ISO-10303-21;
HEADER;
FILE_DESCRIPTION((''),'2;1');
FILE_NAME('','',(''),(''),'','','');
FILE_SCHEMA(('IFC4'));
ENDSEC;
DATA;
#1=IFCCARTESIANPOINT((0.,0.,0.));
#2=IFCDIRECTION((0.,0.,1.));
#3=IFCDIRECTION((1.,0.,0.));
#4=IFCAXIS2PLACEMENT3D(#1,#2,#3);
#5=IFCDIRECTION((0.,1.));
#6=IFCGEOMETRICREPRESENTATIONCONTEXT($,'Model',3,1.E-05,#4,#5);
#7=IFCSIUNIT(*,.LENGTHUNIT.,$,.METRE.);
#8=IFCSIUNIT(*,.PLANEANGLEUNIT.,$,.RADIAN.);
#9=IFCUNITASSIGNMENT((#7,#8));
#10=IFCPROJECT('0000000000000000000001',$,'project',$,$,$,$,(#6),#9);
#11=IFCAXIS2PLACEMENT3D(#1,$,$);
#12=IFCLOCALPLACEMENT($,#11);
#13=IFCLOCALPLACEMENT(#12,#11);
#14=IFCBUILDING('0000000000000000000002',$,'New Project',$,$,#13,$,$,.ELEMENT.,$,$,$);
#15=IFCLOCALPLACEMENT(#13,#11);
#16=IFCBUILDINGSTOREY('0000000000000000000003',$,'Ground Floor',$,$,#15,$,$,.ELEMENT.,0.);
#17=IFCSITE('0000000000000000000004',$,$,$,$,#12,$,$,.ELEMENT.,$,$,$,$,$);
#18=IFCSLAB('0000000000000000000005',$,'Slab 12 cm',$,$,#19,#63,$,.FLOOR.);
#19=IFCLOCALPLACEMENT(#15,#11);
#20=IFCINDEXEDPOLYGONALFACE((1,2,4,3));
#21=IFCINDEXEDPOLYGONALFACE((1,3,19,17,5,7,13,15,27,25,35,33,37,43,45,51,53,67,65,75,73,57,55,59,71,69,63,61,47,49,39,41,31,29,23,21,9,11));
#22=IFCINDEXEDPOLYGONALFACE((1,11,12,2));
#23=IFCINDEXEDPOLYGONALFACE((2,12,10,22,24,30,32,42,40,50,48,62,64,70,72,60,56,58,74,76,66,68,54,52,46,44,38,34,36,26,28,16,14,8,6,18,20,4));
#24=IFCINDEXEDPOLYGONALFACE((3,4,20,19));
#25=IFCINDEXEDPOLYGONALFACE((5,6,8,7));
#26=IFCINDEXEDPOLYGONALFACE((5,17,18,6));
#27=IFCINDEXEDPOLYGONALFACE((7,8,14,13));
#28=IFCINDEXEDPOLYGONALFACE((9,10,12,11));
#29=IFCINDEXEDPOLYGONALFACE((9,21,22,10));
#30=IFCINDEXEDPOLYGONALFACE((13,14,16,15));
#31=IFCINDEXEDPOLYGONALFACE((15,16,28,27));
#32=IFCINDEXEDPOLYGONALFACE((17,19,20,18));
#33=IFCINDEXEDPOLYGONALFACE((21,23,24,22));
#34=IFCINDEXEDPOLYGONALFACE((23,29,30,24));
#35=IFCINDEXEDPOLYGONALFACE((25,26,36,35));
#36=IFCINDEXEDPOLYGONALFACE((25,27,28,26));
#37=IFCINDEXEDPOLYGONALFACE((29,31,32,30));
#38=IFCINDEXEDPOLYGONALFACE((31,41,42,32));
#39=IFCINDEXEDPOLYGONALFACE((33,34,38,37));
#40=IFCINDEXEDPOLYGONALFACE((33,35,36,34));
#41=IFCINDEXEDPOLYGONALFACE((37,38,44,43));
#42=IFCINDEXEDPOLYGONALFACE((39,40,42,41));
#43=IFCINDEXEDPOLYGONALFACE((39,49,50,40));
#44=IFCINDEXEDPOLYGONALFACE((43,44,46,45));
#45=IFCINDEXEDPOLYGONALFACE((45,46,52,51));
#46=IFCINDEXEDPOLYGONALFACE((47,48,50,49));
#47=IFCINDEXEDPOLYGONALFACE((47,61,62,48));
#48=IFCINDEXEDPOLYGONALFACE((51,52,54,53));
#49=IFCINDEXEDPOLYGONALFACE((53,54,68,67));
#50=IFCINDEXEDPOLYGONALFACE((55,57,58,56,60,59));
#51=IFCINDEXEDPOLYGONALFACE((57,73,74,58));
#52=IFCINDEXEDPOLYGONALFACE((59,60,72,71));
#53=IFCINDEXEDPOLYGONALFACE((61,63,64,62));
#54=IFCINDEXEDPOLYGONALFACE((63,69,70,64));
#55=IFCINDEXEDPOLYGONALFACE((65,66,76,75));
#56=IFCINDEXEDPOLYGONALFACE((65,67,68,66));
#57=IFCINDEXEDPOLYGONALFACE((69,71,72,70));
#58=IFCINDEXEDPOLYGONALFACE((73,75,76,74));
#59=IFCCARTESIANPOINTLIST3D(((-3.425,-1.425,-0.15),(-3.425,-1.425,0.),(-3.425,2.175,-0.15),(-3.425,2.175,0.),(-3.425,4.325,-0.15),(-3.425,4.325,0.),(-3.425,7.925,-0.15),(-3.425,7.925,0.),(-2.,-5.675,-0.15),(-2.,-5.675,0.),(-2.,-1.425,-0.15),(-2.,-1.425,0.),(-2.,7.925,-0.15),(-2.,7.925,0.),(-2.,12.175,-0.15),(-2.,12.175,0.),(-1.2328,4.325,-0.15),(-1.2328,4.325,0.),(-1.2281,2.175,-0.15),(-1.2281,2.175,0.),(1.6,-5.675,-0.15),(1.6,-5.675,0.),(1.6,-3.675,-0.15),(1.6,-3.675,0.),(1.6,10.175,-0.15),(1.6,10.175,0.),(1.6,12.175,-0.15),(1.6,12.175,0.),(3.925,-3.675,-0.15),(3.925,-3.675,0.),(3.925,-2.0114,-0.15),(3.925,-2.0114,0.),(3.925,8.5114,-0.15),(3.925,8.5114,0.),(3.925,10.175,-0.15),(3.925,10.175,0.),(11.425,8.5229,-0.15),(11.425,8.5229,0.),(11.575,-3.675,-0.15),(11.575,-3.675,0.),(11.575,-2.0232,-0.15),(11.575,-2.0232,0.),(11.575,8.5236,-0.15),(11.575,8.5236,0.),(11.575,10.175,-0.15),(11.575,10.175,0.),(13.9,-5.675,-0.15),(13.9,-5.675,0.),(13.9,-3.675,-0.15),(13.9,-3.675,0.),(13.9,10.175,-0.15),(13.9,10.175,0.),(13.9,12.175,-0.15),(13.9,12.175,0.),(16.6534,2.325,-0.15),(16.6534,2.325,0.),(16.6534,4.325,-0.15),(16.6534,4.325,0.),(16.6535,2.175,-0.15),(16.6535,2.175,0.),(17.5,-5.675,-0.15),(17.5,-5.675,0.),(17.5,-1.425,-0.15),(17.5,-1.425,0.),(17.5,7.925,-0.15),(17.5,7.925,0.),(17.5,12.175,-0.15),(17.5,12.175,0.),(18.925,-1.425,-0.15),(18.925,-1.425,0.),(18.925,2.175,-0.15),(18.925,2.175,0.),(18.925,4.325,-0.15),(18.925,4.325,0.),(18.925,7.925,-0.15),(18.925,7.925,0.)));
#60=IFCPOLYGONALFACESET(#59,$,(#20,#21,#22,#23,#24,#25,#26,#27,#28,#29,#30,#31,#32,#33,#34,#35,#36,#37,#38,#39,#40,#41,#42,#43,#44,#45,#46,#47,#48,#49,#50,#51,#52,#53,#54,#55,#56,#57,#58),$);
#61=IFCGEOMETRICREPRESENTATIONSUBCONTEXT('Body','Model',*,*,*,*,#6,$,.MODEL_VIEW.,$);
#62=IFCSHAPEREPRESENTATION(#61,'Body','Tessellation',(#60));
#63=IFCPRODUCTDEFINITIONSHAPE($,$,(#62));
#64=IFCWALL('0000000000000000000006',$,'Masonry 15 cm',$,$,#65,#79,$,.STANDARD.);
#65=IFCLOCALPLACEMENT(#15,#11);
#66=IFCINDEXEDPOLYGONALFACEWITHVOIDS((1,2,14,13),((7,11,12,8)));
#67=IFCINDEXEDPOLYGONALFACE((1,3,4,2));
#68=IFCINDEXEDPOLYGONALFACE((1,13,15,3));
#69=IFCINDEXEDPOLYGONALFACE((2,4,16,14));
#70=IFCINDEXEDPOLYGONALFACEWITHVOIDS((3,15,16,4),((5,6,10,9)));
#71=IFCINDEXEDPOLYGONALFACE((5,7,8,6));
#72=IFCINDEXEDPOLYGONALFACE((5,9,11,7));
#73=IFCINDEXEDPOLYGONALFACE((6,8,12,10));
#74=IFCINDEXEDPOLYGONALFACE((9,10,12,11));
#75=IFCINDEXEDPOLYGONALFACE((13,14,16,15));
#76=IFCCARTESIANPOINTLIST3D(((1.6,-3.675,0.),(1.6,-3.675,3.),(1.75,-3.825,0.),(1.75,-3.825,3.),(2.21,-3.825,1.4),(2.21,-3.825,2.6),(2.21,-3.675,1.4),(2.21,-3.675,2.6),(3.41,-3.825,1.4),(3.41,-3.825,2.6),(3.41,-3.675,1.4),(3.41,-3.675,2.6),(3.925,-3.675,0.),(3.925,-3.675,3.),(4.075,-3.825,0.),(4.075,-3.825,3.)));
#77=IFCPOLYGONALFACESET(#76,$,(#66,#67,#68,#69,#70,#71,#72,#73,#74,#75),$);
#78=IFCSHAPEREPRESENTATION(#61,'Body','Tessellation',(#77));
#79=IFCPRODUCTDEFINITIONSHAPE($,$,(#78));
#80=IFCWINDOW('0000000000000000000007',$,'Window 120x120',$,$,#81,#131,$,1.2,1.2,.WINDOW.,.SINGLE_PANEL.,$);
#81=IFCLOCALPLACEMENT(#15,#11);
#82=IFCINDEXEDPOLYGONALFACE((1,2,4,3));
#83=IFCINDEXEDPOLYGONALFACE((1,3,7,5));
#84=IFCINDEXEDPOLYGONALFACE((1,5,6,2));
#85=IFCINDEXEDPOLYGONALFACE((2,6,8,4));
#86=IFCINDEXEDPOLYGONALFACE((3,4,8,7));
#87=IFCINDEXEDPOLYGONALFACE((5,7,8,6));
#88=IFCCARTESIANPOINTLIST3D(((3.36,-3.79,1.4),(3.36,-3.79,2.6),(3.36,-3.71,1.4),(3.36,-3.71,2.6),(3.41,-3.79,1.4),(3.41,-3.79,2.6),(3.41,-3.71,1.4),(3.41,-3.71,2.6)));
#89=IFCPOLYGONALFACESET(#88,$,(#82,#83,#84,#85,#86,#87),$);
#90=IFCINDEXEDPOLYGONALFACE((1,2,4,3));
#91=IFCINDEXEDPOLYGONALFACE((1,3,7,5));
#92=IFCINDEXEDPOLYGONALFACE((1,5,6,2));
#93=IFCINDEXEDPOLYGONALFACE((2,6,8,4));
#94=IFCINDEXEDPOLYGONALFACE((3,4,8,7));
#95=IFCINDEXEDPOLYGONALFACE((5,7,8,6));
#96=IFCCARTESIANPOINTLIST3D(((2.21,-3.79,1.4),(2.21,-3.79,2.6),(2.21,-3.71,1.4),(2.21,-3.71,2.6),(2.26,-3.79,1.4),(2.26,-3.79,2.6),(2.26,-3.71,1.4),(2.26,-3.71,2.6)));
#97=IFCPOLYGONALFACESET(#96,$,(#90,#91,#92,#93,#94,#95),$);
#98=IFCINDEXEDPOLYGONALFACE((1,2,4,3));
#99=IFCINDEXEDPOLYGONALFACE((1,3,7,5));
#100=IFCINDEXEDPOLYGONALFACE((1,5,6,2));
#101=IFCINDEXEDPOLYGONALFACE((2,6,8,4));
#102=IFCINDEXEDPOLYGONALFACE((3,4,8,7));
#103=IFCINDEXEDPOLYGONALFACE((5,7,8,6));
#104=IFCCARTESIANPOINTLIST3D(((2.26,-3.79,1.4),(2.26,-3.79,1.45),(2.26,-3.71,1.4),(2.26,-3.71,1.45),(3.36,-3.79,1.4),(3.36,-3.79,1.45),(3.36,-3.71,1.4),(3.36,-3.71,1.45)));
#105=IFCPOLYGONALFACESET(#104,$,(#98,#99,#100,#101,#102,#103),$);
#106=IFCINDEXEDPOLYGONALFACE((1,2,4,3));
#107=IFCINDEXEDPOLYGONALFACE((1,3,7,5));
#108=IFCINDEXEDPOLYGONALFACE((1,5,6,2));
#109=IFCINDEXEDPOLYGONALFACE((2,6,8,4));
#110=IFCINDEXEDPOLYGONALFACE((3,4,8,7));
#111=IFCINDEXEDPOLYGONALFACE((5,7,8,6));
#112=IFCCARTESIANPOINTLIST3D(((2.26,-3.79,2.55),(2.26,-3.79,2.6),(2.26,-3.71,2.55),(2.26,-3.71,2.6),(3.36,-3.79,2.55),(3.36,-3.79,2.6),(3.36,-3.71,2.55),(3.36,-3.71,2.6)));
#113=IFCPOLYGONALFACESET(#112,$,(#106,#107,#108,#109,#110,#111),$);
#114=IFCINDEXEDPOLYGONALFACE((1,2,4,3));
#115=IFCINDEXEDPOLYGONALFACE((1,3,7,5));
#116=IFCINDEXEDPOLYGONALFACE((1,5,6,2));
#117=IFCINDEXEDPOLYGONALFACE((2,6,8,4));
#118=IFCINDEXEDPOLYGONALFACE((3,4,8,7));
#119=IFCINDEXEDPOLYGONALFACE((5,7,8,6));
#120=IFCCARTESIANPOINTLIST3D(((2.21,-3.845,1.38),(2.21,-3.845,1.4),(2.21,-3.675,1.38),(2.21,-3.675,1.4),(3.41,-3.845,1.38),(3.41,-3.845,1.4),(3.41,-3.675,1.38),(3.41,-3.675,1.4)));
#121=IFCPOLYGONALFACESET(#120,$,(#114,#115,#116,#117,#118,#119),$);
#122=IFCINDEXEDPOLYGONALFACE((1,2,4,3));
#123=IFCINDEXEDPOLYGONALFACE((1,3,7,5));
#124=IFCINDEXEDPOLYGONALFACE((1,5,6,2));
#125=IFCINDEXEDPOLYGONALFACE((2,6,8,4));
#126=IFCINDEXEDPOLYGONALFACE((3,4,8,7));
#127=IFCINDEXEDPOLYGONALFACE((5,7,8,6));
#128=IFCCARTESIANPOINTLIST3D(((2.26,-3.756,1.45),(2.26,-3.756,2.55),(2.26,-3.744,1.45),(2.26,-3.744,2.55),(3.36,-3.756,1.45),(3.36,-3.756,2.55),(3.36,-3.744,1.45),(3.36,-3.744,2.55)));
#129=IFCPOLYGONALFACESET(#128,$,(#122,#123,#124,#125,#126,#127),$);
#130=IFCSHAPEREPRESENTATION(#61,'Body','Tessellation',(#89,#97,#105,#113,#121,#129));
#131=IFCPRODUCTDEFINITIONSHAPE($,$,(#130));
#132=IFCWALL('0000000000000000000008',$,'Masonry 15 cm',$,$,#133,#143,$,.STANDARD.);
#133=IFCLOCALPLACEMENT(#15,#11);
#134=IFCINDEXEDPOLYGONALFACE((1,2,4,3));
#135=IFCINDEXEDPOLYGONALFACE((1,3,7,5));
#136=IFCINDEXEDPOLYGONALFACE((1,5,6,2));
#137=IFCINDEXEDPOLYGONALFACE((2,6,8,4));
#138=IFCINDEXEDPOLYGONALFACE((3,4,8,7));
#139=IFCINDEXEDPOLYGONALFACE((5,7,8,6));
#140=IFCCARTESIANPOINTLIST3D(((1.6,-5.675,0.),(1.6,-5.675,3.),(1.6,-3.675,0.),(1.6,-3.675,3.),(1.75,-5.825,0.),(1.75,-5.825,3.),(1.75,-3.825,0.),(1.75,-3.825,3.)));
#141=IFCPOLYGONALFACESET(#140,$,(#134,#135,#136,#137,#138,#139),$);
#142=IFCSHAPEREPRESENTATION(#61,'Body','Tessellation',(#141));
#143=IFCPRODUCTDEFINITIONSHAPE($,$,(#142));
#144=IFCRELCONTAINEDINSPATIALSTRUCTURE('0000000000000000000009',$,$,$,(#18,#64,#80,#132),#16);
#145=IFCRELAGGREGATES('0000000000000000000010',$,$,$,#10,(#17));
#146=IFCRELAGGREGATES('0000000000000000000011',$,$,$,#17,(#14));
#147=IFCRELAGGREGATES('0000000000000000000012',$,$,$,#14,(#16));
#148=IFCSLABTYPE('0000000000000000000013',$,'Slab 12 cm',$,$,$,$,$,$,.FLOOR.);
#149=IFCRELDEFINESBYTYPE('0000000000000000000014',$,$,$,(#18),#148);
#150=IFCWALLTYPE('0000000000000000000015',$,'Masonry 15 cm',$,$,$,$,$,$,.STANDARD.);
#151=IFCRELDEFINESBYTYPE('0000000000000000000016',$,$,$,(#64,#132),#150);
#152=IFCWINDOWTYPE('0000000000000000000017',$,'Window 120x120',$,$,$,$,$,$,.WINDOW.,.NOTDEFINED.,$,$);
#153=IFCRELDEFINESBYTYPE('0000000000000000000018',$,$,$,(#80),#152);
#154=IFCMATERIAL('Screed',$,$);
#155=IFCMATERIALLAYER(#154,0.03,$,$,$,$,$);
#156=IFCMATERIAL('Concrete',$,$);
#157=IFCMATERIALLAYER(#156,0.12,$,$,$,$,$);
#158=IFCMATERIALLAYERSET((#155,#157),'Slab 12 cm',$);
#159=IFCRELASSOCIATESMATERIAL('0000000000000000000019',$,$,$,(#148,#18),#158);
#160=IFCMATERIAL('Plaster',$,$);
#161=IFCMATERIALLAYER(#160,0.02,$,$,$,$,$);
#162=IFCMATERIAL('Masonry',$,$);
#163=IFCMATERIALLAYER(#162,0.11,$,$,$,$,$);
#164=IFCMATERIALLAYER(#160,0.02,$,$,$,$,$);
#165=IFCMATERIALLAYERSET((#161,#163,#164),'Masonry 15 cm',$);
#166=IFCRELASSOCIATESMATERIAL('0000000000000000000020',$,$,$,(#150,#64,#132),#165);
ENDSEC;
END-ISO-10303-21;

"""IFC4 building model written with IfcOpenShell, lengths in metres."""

from ifc_helpers import new_model, si_unit, direction, frame, frame_2d, origin, origin_with_axes, place, context, subcontext, project, spatial, polyline, rectangle, outline, extrude, material, layer, layer_set, layer_usage, type_object, element, fill, save


model = new_model("IFC4")

# Units and contexts
model_context = context("Model", 3, precision=1e-05, world=origin_with_axes(), true_north=direction((0.0, 1.0)))
body_context = subcontext(model_context, "Body", "Model", "MODEL_VIEW")
ifc_project = project(units=[si_unit("LENGTHUNIT", "METRE"), si_unit("PLANEANGLEUNIT", "RADIAN")], contexts=[model_context])

# Site, building, storey
site_placement = place(None, origin())
site = spatial("IfcSite", under=ifc_project, at=site_placement, CompositionType="ELEMENT")
building_placement = place(site_placement, origin())
building = spatial("IfcBuilding", under=site, at=building_placement, Name="New Project", CompositionType="ELEMENT")
storey_placement = place(building_placement, origin())
storey = spatial("IfcBuildingStorey", under=building, at=storey_placement, Name="Ground Floor", CompositionType="ELEMENT", Elevation=0.0)

# Slab
ifc_material_1 = material(Name="Screed")
ifc_layer_1 = layer(ifc_material_1, 0.03)
ifc_material_2 = material(Name="Concrete")
ifc_layer_2 = layer(ifc_material_2, 0.12)
ifc_layer_set_1 = layer_set([ifc_layer_1, ifc_layer_2], Name="Slab 12 cm")
ifc_layer_usage_1 = layer_usage(ifc_layer_set_1, "AXIS3", "NEGATIVE", 0.15)
slab_type = type_object("IfcSlabType", Name="Slab 12 cm", PredefinedType="FLOOR", material=ifc_layer_set_1)
slab_placement = place(storey_placement, frame((0.0, 0.0, -0.15)))
element("IfcSlab", 1, at=slab_placement, inside=storey, type_object=slab_type, material=ifc_layer_usage_1, Name="Slab 12 cm", PredefinedType="FLOOR", context=body_context, shape_type="SweptSolid", body=[
    extrude(outline(polyline([(-2.0, 7.925), (-3.425, 7.925), (-3.425, 4.325), (-1.2328, 4.325), (-1.2281, 2.175), (-3.425, 2.175), (-3.425, -1.425), (-2.0, -1.425), (-2.0, -5.675), (1.6, -5.675), (1.6, -3.675), (3.925, -3.675), (3.925, -2.0114), (11.575, -2.0232), (11.575, -3.675), (13.9, -3.675), (13.9, -5.675), (17.5, -5.675), (17.5, -1.425), (18.925, -1.425), (18.925, 2.175), (16.6535, 2.175), (16.6534, 2.325), (16.6534, 4.325), (18.925, 4.325), (18.925, 7.925), (17.5, 7.925), (17.5, 12.175), (13.9, 12.175), (13.9, 10.175), (11.575, 10.175), (11.575, 8.5236), (11.425, 8.5229), (3.925, 8.5114), (3.925, 10.175), (1.6, 10.175), (1.6, 12.175), (-2.0, 12.175), (-2.0, 7.925)])), origin(), (0.0, 0.0, 1.0), 0.15),
])

# Wall, opening, window
ifc_material_3 = material(Name="Plaster")
ifc_layer_3 = layer(ifc_material_3, 0.02)
ifc_material_4 = material(Name="Masonry")
ifc_layer_4 = layer(ifc_material_4, 0.11)
ifc_layer_5 = layer(ifc_material_3, 0.02)
ifc_layer_set_2 = layer_set([ifc_layer_3, ifc_layer_4, ifc_layer_5], Name="Masonry 15 cm")
ifc_layer_usage_2 = layer_usage(ifc_layer_set_2, "AXIS2", "NEGATIVE", 0.075)
wall_type = type_object("IfcWallType", Name="Masonry 15 cm", PredefinedType="STANDARD", material=ifc_layer_set_2)
wall_1_placement = place(storey_placement, frame((4.0, -3.75, 0.0), z_axis=(0.0, 0.0, 1.0), x_axis=(-1.0, 0.0, 0.0)))
wall_1 = element("IfcWall", 2, at=wall_1_placement, inside=storey, type_object=wall_type, material=ifc_layer_usage_2, Name="Masonry 15 cm", PredefinedType="STANDARD", context=body_context, shape_type="SweptSolid", body=[
    extrude(outline(polyline([(0.075, -0.075), (2.4, -0.075), (2.25, 0.075), (-0.075, 0.075), (0.075, -0.075)])), origin(), (0.0, 0.0, 1.0), 3.0),
])
opening_1_placement = place(wall_1_placement, frame((0.59, 0.0, 1.4)))
opening_1 = element("IfcOpeningElement", 3, at=opening_1_placement, cuts=wall_1, PredefinedType="OPENING", context=body_context, shape_type="SweptSolid", body=[
    extrude(rectangle(XDim=1.2, YDim=0.25, at=frame_2d((0.6, 0.0))), origin(), (0.0, 0.0, 1.0), 1.2),
])
window_type = type_object("IfcWindowType", Name="Window 120x120", PartitioningType="NOTDEFINED", PredefinedType="WINDOW")
window_1_placement = place(opening_1_placement, origin())
window_1 = element("IfcWindow", 4, at=window_1_placement, inside=storey, type_object=window_type, Name="Window 120x120", OverallHeight=1.2, OverallWidth=1.2, PartitioningType="SINGLE_PANEL", PredefinedType="WINDOW", context=body_context, shape_type="SweptSolid", body=[
    extrude(outline(polyline([(0.0, -0.04), (0.05, -0.04), (0.05, 0.04), (0.0, 0.04), (0.0, -0.04)])), origin(), (0.0, 0.0, 1.0), 1.2),
    extrude(outline(polyline([(1.15, -0.04), (1.2, -0.04), (1.2, 0.04), (1.15, 0.04), (1.15, -0.04)])), origin(), (0.0, 0.0, 1.0), 1.2),
    extrude(outline(polyline([(0.05, -0.04), (1.15, -0.04), (1.15, 0.04), (0.05, 0.04), (0.05, -0.04)])), origin(), (0.0, 0.0, 1.0), 0.05),
    extrude(outline(polyline([(0.05, -0.04), (1.15, -0.04), (1.15, 0.04), (0.05, 0.04), (0.05, -0.04)])), frame((0.0, 0.0, 1.15)), (0.0, 0.0, 1.0), 0.05),
    extrude(outline(polyline([(0.0, -0.075), (1.2, -0.075), (1.2, 0.095), (0.0, 0.095), (0.0, -0.075)])), frame((0.0, 0.0, -0.02)), (0.0, 0.0, 1.0), 0.02),
    extrude(outline(polyline([(0.05, -0.006), (1.15, -0.006), (1.15, 0.006), (0.05, 0.006), (0.05, -0.006)])), frame((0.0, 0.0, 0.05)), (0.0, 0.0, 1.0), 1.1),
])
fill(opening_1, window_1)

# Wall
wall_2_placement = place(storey_placement, frame((1.675, -3.75, 0.0), z_axis=(0.0, 0.0, 1.0), x_axis=(0.0, -1.0, 0.0)))
element("IfcWall", 5, at=wall_2_placement, inside=storey, type_object=wall_type, material=ifc_layer_usage_2, Name="Masonry 15 cm", PredefinedType="STANDARD", context=body_context, shape_type="SweptSolid", body=[
    extrude(outline(polyline([(-0.075, -0.075), (1.925, -0.075), (2.075, 0.075), (0.075, 0.075), (-0.075, -0.075)])), origin(), (0.0, 0.0, 1.0), 3.0),
])

save(model, "model.ifc")
